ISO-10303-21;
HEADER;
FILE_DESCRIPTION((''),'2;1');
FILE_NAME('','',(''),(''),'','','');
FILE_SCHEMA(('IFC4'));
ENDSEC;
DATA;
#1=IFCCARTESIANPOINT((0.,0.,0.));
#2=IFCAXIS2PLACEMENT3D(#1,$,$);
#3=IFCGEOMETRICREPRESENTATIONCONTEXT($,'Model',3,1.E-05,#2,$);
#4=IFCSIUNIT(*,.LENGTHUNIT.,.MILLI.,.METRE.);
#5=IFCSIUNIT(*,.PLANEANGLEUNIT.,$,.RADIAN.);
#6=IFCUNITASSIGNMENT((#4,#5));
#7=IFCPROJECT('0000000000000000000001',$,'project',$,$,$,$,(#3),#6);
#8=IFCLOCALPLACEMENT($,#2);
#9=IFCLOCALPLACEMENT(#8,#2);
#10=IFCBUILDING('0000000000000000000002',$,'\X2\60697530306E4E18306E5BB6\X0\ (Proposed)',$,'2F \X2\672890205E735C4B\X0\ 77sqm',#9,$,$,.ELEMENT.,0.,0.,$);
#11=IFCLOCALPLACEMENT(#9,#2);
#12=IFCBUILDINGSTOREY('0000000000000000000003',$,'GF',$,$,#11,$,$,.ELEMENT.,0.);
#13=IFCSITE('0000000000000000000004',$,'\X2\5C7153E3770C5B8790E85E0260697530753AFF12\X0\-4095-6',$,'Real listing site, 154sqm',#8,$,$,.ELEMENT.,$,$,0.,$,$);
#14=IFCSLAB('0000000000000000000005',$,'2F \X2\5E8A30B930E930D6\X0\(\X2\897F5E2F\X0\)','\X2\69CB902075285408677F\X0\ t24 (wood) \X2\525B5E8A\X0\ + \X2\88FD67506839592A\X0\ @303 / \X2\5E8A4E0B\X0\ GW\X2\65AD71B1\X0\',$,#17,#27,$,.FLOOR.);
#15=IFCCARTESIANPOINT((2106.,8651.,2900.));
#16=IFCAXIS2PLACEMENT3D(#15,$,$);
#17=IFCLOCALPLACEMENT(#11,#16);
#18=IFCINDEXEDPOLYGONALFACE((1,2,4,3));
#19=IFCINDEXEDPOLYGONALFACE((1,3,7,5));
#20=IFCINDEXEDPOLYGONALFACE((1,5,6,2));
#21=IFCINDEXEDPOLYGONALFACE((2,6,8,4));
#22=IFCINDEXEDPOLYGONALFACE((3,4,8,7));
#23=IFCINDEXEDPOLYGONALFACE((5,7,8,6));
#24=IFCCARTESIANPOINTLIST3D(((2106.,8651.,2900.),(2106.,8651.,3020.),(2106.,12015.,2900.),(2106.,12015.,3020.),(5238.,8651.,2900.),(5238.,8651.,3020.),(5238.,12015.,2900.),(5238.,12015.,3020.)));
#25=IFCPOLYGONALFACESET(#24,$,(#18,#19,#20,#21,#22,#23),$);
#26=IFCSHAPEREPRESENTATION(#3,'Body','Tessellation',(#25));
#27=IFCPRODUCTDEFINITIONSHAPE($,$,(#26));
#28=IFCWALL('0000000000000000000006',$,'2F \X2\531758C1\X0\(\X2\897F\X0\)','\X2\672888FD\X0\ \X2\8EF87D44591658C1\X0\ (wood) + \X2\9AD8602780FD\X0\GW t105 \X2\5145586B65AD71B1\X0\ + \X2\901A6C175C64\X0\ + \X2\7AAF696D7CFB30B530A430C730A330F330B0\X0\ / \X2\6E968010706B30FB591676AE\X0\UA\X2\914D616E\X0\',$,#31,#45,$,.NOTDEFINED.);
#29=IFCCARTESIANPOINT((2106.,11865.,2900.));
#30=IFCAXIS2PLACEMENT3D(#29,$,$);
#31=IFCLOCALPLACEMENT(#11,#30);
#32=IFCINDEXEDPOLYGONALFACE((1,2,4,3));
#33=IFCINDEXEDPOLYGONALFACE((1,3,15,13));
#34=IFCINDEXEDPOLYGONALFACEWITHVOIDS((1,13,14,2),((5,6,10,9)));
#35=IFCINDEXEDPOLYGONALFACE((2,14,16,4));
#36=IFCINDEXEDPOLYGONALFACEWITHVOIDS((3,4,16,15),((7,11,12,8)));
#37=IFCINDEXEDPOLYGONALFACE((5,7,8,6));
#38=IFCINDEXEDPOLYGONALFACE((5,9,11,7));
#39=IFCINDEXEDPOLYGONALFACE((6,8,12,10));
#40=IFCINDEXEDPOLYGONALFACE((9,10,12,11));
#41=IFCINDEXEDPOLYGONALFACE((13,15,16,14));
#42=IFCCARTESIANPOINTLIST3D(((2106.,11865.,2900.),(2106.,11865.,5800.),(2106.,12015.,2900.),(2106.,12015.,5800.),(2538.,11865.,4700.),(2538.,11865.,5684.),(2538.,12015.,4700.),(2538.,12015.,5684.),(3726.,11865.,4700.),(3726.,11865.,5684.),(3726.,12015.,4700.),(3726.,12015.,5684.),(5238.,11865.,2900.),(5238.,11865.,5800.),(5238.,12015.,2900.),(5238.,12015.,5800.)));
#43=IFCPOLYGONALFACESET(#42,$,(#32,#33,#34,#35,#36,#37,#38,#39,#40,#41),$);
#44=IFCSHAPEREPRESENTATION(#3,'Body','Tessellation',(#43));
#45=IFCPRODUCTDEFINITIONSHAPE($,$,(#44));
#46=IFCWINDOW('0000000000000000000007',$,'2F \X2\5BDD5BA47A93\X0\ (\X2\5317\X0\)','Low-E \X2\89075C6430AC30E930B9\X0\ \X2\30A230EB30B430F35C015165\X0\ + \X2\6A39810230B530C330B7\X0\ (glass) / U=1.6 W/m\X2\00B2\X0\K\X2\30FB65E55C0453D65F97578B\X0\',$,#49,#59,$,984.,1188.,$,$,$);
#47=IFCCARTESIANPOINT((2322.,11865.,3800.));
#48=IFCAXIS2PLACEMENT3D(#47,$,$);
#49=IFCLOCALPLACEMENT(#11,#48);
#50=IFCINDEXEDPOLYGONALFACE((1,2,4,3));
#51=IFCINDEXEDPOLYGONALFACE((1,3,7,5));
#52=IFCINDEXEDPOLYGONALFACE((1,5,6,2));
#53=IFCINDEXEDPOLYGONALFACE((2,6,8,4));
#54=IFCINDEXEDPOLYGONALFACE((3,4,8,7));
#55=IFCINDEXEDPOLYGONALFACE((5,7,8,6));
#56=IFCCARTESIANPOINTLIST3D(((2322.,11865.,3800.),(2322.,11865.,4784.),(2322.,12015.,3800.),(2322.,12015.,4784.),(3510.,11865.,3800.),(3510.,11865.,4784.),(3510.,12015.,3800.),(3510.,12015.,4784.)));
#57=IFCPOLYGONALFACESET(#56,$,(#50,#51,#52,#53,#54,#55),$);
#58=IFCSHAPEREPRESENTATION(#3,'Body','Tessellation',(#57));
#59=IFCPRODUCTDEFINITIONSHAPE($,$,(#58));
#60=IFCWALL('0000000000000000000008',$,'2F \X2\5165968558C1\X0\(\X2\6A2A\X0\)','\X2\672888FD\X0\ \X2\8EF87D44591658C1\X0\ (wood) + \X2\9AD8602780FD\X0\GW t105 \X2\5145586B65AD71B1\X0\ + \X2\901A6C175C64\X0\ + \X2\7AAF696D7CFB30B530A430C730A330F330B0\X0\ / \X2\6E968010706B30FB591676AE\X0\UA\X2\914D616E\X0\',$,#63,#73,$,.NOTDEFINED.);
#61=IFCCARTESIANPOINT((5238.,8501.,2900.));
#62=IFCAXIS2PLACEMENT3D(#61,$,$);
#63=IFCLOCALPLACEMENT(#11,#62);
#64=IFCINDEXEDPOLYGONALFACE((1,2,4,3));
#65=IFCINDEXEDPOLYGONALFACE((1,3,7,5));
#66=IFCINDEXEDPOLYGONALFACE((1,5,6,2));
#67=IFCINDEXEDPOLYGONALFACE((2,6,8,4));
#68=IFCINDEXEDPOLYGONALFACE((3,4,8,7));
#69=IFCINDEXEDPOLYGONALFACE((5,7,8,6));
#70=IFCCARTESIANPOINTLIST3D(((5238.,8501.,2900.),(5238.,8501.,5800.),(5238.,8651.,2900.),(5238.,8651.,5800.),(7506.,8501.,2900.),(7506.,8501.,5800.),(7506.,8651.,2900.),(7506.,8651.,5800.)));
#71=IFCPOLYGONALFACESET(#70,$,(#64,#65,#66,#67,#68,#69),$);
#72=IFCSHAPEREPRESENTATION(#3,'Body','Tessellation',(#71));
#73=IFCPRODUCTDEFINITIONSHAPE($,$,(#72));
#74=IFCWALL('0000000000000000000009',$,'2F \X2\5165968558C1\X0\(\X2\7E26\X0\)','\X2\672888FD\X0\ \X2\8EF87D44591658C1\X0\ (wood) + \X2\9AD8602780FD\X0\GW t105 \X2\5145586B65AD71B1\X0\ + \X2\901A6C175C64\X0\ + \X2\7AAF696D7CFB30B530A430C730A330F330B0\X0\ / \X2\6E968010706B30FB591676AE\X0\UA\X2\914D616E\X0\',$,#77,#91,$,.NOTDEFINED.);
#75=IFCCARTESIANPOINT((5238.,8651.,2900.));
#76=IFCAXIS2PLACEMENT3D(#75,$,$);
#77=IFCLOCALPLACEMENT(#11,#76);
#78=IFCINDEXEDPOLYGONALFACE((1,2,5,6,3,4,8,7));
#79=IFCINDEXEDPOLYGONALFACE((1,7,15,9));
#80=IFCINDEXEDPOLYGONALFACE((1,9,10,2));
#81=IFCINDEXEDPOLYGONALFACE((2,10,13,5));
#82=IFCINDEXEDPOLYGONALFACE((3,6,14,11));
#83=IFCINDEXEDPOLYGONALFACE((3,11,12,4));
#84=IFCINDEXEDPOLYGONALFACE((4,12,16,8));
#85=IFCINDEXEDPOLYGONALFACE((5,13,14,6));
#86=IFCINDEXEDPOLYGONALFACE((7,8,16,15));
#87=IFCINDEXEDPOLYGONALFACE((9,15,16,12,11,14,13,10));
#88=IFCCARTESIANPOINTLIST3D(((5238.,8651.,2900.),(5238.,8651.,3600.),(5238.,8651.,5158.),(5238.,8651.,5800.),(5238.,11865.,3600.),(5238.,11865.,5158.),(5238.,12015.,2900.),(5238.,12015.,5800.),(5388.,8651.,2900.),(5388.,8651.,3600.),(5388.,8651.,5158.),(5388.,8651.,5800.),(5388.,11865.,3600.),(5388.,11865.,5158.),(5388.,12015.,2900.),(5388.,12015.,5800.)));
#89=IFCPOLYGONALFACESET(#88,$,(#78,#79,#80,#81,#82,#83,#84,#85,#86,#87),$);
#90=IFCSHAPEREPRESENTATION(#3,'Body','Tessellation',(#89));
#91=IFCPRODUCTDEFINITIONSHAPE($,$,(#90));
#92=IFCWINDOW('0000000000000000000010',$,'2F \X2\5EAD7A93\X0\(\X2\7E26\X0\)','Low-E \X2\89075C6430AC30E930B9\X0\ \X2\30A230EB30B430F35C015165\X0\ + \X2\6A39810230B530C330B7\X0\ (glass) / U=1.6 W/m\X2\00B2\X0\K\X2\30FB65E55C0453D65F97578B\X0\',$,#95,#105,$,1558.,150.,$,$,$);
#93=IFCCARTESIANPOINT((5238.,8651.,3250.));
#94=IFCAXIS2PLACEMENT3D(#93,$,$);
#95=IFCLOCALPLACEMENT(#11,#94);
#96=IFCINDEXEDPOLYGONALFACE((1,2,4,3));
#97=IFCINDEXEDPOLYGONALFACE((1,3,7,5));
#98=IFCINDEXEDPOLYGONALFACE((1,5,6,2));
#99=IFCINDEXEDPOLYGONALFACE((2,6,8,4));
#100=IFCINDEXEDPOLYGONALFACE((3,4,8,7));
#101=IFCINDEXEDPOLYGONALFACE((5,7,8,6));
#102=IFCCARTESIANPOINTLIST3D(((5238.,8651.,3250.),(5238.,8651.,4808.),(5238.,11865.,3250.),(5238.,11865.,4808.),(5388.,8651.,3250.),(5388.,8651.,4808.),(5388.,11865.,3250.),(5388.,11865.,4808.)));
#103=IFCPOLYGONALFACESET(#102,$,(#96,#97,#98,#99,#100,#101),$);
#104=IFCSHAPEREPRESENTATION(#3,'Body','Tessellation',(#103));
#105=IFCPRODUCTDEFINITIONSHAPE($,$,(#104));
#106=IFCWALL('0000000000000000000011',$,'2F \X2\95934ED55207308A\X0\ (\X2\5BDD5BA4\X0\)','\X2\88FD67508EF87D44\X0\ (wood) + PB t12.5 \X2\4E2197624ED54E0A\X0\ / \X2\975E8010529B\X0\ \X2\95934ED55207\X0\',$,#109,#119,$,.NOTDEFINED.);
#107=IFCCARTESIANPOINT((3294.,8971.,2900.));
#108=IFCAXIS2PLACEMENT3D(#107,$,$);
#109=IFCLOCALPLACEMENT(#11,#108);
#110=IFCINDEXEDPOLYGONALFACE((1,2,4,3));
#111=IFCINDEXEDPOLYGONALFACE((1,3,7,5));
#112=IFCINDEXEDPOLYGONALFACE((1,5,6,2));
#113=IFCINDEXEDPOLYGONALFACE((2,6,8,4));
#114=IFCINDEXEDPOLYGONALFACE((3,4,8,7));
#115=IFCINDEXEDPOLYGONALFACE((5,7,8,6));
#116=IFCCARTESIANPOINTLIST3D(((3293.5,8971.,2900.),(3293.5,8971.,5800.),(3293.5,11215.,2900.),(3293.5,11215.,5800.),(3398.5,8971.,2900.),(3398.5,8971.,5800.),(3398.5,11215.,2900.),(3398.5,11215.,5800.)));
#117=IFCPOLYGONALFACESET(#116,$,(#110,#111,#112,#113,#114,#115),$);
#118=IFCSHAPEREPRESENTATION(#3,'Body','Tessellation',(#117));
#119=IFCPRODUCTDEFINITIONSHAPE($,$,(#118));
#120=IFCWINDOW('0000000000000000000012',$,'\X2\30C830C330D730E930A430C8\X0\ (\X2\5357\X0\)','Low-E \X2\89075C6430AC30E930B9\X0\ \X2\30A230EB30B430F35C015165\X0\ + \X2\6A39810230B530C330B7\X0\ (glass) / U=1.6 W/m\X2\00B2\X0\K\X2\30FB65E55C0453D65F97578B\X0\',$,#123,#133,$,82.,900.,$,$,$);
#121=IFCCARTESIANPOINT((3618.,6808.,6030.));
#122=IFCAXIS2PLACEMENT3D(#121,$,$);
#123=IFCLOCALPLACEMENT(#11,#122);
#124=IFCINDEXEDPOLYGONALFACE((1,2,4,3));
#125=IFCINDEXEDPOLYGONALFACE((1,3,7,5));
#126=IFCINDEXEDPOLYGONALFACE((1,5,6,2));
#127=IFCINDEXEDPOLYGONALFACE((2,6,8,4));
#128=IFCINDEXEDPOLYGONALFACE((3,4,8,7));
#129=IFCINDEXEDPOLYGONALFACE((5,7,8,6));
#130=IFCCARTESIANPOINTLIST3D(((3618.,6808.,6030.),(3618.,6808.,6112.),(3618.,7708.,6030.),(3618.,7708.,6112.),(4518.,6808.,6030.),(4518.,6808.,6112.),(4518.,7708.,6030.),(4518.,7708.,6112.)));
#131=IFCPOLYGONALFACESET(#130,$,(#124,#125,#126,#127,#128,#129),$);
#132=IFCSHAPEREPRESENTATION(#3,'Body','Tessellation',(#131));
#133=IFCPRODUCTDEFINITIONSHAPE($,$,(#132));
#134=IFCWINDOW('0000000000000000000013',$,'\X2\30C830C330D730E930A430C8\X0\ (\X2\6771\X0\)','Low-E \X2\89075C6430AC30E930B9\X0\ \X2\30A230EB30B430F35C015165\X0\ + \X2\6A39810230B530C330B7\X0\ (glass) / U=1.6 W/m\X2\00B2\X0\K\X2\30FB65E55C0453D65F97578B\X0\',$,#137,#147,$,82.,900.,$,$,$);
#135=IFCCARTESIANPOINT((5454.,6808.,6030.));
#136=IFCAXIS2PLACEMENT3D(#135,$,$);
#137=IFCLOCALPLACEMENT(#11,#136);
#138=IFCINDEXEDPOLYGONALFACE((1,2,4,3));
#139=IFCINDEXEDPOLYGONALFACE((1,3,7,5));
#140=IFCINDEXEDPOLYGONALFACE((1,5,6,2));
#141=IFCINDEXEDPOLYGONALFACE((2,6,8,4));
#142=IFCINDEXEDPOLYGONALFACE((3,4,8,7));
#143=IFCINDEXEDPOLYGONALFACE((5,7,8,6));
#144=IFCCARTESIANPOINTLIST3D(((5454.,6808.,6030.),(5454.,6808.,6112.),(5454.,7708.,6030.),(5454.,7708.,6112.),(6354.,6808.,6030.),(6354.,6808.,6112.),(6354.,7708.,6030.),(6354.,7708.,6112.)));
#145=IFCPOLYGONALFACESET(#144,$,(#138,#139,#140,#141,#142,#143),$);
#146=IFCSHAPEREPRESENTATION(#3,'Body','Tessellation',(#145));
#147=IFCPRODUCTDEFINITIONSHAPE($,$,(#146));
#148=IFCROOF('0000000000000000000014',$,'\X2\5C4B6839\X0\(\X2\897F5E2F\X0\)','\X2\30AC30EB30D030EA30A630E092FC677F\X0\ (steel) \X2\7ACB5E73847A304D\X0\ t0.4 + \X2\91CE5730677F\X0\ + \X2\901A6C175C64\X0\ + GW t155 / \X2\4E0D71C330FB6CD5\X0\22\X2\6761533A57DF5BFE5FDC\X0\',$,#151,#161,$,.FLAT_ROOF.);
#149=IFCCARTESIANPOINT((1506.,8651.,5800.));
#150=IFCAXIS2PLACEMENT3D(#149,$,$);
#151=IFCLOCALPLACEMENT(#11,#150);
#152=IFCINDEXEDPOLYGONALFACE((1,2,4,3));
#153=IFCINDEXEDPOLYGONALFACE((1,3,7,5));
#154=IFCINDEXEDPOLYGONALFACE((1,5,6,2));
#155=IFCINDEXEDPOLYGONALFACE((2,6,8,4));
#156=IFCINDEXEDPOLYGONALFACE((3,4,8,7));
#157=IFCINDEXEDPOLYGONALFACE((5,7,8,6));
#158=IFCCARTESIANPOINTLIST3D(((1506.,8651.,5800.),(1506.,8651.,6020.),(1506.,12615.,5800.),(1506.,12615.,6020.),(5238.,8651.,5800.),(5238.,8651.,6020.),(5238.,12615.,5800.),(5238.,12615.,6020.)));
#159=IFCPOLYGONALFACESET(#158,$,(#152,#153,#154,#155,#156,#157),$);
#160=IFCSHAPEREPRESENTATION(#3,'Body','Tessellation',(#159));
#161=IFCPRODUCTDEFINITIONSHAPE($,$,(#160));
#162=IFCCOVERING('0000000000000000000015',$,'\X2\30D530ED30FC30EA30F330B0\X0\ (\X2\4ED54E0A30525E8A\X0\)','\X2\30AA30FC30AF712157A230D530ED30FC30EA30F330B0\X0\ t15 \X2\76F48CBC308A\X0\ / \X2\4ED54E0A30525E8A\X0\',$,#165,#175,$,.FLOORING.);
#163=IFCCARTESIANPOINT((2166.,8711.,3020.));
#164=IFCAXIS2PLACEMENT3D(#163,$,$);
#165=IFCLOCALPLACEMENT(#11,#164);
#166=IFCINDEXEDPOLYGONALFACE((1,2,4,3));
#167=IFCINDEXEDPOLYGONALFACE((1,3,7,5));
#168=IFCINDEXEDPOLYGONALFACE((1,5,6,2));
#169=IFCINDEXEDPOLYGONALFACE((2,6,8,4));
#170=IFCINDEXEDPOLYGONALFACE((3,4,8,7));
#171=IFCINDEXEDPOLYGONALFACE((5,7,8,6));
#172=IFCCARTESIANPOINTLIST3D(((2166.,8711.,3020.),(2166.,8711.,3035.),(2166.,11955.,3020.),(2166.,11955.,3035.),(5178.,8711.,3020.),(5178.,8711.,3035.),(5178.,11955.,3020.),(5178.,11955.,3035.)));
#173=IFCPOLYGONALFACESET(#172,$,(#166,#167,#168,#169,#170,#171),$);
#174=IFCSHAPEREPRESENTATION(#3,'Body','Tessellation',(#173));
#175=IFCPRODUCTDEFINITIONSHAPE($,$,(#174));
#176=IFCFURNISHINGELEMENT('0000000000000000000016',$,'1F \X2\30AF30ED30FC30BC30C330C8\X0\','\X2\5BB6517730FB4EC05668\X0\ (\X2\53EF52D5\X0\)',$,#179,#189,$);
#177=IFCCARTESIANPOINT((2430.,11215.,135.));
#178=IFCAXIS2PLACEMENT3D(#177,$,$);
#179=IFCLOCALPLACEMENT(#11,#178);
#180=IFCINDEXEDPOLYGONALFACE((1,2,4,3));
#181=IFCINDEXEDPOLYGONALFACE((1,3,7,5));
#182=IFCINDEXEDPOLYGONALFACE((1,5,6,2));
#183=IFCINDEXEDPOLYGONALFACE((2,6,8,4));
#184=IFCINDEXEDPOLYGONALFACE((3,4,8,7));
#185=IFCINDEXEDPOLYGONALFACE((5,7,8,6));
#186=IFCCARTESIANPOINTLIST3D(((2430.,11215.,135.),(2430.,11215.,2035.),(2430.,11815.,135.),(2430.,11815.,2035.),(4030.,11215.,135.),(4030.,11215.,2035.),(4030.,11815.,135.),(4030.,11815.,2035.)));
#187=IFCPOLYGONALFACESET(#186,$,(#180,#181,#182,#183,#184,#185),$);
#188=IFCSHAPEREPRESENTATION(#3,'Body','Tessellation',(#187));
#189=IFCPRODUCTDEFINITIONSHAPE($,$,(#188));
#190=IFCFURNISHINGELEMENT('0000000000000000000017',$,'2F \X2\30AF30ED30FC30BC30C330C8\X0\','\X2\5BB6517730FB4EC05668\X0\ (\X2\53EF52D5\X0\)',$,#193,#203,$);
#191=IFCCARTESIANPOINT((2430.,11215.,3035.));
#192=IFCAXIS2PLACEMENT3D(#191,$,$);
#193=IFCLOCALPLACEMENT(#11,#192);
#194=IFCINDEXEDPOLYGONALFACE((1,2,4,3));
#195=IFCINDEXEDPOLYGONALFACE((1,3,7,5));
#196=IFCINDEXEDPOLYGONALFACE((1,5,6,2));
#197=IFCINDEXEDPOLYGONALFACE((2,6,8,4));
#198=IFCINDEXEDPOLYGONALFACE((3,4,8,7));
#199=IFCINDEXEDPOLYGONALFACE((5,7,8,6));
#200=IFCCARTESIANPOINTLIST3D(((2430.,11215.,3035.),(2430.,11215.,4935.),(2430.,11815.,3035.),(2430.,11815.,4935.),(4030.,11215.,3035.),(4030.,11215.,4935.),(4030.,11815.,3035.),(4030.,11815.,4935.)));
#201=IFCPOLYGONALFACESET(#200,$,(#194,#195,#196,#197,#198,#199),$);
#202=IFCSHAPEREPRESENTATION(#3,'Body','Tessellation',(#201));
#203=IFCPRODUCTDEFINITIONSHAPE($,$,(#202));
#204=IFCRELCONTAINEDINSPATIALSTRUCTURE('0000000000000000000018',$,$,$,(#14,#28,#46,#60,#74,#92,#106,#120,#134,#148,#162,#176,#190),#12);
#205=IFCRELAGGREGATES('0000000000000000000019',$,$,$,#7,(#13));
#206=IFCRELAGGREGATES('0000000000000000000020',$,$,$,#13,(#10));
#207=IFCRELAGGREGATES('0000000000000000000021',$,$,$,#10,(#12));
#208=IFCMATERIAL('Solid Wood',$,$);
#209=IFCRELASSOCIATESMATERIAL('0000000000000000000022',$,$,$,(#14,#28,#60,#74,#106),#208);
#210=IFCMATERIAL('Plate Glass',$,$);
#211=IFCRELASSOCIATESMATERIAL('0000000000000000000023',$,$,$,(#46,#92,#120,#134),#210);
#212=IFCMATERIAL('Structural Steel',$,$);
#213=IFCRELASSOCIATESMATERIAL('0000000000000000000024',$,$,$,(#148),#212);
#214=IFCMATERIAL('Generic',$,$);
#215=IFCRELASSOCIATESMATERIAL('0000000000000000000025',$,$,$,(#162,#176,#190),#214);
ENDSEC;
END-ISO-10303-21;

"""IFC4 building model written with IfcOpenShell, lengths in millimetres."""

from ifc_helpers import new_model, si_unit, frame, frame_2d, origin, place, context, project, spatial, rectangle, extrude, material, element, fill, save


model = new_model("IFC4")

# Units and contexts
model_context = context("Model", 3, precision=1e-05, world=origin())
ifc_project = project(units=[si_unit("LENGTHUNIT", "METRE", prefix="MILLI"), si_unit("PLANEANGLEUNIT", "RADIAN")], contexts=[model_context])

# Site, building, storey
site_placement = place(None, origin())
site = spatial("IfcSite", under=ifc_project, at=site_placement, Name="山口県宇部市恩田町２-4095-6", ObjectType="Real listing site, 154sqm", CompositionType="ELEMENT", RefElevation=0.0)
building_placement = place(site_placement, origin())
building = spatial("IfcBuilding", under=site, at=building_placement, Name="恩田の丘の家 (Proposed)", ObjectType="2F 木造平屋 77sqm", CompositionType="ELEMENT", ElevationOfRefHeight=0.0, ElevationOfTerrain=0.0)
storey_placement = place(building_placement, origin())
storey = spatial("IfcBuildingStorey", under=building, at=storey_placement, Name="GF", CompositionType="ELEMENT", Elevation=0.0)

# Slab
ifc_material_1 = material(Name="Solid Wood")
slab_placement = place(storey_placement, frame((2106.0, 8651.0, 2900.0)))
element("IfcSlab", 1, at=slab_placement, inside=storey, material=ifc_material_1, Name="2F 床スラブ(西帯)", Description="構造用合板 t24 (wood) 剛床 + 製材根太 @303 / 床下 GW断熱", PredefinedType="FLOOR", context=model_context, shape_type="SweptSolid", body=[
    extrude(rectangle(XDim=3132.0, YDim=3364.0, at=frame_2d((1566.0, 1682.0))), frame((2106.0, 8651.0, 2900.0)), (0.0, 0.0, 1.0), 120.0),
])

# Wall, opening, window
wall_1_placement = place(storey_placement, frame((2106.0, 11865.0, 2900.0)))
wall_1 = element("IfcWall", 2, at=wall_1_placement, inside=storey, material=ifc_material_1, Name="2F 北壁(西)", Description="木製 軸組外壁 (wood) + 高性能GW t105 充填断熱 + 通気層 + 窯業系サイディング / 準耐火・外皮UA配慮", PredefinedType="NOTDEFINED", context=model_context, shape_type="SweptSolid", body=[
    extrude(rectangle(XDim=3132.0, YDim=150.0, at=frame_2d((1566.0, 75.0))), frame((2106.0, 11865.0, 2900.0)), (0.0, 0.0, 1.0), 2900.0),
])
opening_1_placement = place(storey_placement, frame((2322.0, 11865.0, 3800.0)))
opening_1 = element("IfcOpeningElement", 3, at=opening_1_placement, cuts=wall_1, PredefinedType="NOTDEFINED", context=model_context, shape_type="SweptSolid", body=[
    extrude(rectangle(XDim=1188.0, YDim=150.0, at=frame_2d((594.0, 75.0))), frame((2322.0, 11865.0, 3800.0)), (0.0, 0.0, 1.0), 984.0),
])
ifc_material_2 = material(Name="Plate Glass")
window_1_placement = place(storey_placement, frame((2322.0, 11865.0, 3800.0)))
window_1 = element("IfcWindow", 4, at=window_1_placement, inside=storey, material=ifc_material_2, Name="2F 寝室窓 (北)", Description="Low-E 複層ガラス アルゴン封入 + 樹脂サッシ (glass) / U=1.6 W/m²K・日射取得型", OverallHeight=984.0, OverallWidth=1188.0, context=model_context, shape_type="SweptSolid", body=[
    extrude(rectangle(XDim=1188.0, YDim=150.0, at=frame_2d((594.0, 75.0))), frame((2322.0, 11865.0, 3800.0)), (0.0, 0.0, 1.0), 984.0),
])
fill(opening_1, window_1)

# Wall
wall_2_placement = place(storey_placement, frame((5238.0, 8501.0, 2900.0)))
element("IfcWall", 5, at=wall_2_placement, inside=storey, material=ifc_material_1, Name="2F 入隅壁(横)", Description="木製 軸組外壁 (wood) + 高性能GW t105 充填断熱 + 通気層 + 窯業系サイディング / 準耐火・外皮UA配慮", PredefinedType="NOTDEFINED", context=model_context, shape_type="SweptSolid", body=[
    extrude(rectangle(XDim=2268.0, YDim=150.0, at=frame_2d((1134.0, 75.0))), frame((5238.0, 8501.0, 2900.0)), (0.0, 0.0, 1.0), 2900.0),
])

# Wall, opening, window
wall_3_placement = place(storey_placement, frame((5238.0, 8651.0, 2900.0)))
wall_3 = element("IfcWall", 6, at=wall_3_placement, inside=storey, material=ifc_material_1, Name="2F 入隅壁(縦)", Description="木製 軸組外壁 (wood) + 高性能GW t105 充填断熱 + 通気層 + 窯業系サイディング / 準耐火・外皮UA配慮", PredefinedType="NOTDEFINED", context=model_context, shape_type="SweptSolid", body=[
    extrude(rectangle(XDim=150.0, YDim=3364.0, at=frame_2d((75.0, 1682.0))), frame((5238.0, 8651.0, 2900.0)), (0.0, 0.0, 1.0), 2900.0),
])
opening_2_placement = place(storey_placement, frame((5238.0, 8651.0, 3250.0)))
opening_2 = element("IfcOpeningElement", 7, at=opening_2_placement, cuts=wall_3, PredefinedType="NOTDEFINED", context=model_context, shape_type="SweptSolid", body=[
    extrude(rectangle(XDim=150.0, YDim=3214.0, at=frame_2d((75.0, 1607.0))), frame((5238.0, 8651.0, 3250.0)), (0.0, 0.0, 1.0), 1558.0),
])
window_2_placement = place(storey_placement, frame((5238.0, 8651.0, 3250.0)))
window_2 = element("IfcWindow", 8, at=window_2_placement, inside=storey, material=ifc_material_2, Name="2F 庭窓(縦)", Description="Low-E 複層ガラス アルゴン封入 + 樹脂サッシ (glass) / U=1.6 W/m²K・日射取得型", OverallHeight=1558.0, OverallWidth=150.0, context=model_context, shape_type="SweptSolid", body=[
    extrude(rectangle(XDim=150.0, YDim=3214.0, at=frame_2d((75.0, 1607.0))), frame((5238.0, 8651.0, 3250.0)), (0.0, 0.0, 1.0), 1558.0),
])
fill(opening_2, window_2)

# Wall
wall_4_placement = place(storey_placement, frame((3294.0, 8971.0, 2900.0)))
element("IfcWall", 9, at=wall_4_placement, inside=storey, material=ifc_material_1, Name="2F 間仕切り (寝室)", Description="製材軸組 (wood) + PB t12.5 両面仕上 / 非耐力 間仕切", PredefinedType="NOTDEFINED", context=model_context, shape_type="SweptSolid", body=[
    extrude(rectangle(XDim=105.0, YDim=2244.0, at=frame_2d((52.0, 1122.0))), frame((3294.0, 8971.0, 2900.0)), (0.0, 0.0, 1.0), 2900.0),
])

# Windows
window_3_placement = place(storey_placement, frame((3618.0, 6808.0, 6030.0)))
element("IfcWindow", 10, at=window_3_placement, inside=storey, material=ifc_material_2, Name="トップライト (南)", Description="Low-E 複層ガラス アルゴン封入 + 樹脂サッシ (glass) / U=1.6 W/m²K・日射取得型", OverallHeight=82.0, OverallWidth=900.0, context=model_context, shape_type="SweptSolid", body=[
    extrude(rectangle(XDim=900.0, YDim=900.0, at=frame_2d((450.0, 450.0))), frame((3618.0, 6808.0, 6030.0)), (0.0, 0.0, 1.0), 82.0),
])
window_4_placement = place(storey_placement, frame((5454.0, 6808.0, 6030.0)))
element("IfcWindow", 11, at=window_4_placement, inside=storey, material=ifc_material_2, Name="トップライト (東)", Description="Low-E 複層ガラス アルゴン封入 + 樹脂サッシ (glass) / U=1.6 W/m²K・日射取得型", OverallHeight=82.0, OverallWidth=900.0, context=model_context, shape_type="SweptSolid", body=[
    extrude(rectangle(XDim=900.0, YDim=900.0, at=frame_2d((450.0, 450.0))), frame((5454.0, 6808.0, 6030.0)), (0.0, 0.0, 1.0), 82.0),
])

# Roof
ifc_material_3 = material(Name="Structural Steel")
for number, where, name in (
    (12, (1506.0, 8651.0, 5800.0), "屋根(西帯)"),
):
    element("IfcRoof", number, at=place(storey_placement, frame(where)), inside=storey, material=ifc_material_3, Name=name, Description="ガルバリウム鋼板 (steel) 立平葺き t0.4 + 野地板 + 通気層 + GW t155 / 不燃・法22条区域対応", PredefinedType="FLAT_ROOF", context=model_context, shape_type="SweptSolid", body=[
        extrude(rectangle(XDim=3732.0, YDim=3964.0, at=frame_2d((1866.0, 1982.0))), frame((1506.0, 8651.0, 5800.0)), (0.0, 0.0, 1.0), 220.0),
    ])

# Covering
ifc_material_4 = material(Name="Generic")
covering_placement = place(storey_placement, frame((2166.0, 8711.0, 3020.0)))
element("IfcCovering", 13, at=covering_placement, inside=storey, material=ifc_material_4, Name="フローリング (仕上げ床)", Description="オーク無垢フローリング t15 直貼り / 仕上げ床", PredefinedType="FLOORING", context=model_context, shape_type="SweptSolid", body=[
    extrude(rectangle(XDim=3012.0, YDim=3244.0, at=frame_2d((1506.0, 1622.0))), frame((2166.0, 8711.0, 3020.0)), (0.0, 0.0, 1.0), 15.0),
])

# Furnishing elements
furnishing_1_placement = place(storey_placement, frame((2430.0, 11215.0, 135.0)))
element("IfcFurnishingElement", 14, at=furnishing_1_placement, inside=storey, material=ifc_material_4, Name="1F クローゼット", Description="家具・什器 (可動)", context=model_context, shape_type="SweptSolid", body=[
    extrude(rectangle(XDim=1600.0, YDim=600.0, at=frame_2d((800.0, 300.0))), frame((2430.0, 11215.0, 135.0)), (0.0, 0.0, 1.0), 1900.0),
])
furnishing_2_placement = place(storey_placement, frame((2430.0, 11215.0, 3035.0)))
element("IfcFurnishingElement", 15, at=furnishing_2_placement, inside=storey, material=ifc_material_4, Name="2F クローゼット", Description="家具・什器 (可動)", context=model_context, shape_type="SweptSolid", body=[
    extrude(rectangle(XDim=1600.0, YDim=600.0, at=frame_2d((800.0, 300.0))), frame((2430.0, 11215.0, 3035.0)), (0.0, 0.0, 1.0), 1900.0),
])

save(model, "model.ifc")
